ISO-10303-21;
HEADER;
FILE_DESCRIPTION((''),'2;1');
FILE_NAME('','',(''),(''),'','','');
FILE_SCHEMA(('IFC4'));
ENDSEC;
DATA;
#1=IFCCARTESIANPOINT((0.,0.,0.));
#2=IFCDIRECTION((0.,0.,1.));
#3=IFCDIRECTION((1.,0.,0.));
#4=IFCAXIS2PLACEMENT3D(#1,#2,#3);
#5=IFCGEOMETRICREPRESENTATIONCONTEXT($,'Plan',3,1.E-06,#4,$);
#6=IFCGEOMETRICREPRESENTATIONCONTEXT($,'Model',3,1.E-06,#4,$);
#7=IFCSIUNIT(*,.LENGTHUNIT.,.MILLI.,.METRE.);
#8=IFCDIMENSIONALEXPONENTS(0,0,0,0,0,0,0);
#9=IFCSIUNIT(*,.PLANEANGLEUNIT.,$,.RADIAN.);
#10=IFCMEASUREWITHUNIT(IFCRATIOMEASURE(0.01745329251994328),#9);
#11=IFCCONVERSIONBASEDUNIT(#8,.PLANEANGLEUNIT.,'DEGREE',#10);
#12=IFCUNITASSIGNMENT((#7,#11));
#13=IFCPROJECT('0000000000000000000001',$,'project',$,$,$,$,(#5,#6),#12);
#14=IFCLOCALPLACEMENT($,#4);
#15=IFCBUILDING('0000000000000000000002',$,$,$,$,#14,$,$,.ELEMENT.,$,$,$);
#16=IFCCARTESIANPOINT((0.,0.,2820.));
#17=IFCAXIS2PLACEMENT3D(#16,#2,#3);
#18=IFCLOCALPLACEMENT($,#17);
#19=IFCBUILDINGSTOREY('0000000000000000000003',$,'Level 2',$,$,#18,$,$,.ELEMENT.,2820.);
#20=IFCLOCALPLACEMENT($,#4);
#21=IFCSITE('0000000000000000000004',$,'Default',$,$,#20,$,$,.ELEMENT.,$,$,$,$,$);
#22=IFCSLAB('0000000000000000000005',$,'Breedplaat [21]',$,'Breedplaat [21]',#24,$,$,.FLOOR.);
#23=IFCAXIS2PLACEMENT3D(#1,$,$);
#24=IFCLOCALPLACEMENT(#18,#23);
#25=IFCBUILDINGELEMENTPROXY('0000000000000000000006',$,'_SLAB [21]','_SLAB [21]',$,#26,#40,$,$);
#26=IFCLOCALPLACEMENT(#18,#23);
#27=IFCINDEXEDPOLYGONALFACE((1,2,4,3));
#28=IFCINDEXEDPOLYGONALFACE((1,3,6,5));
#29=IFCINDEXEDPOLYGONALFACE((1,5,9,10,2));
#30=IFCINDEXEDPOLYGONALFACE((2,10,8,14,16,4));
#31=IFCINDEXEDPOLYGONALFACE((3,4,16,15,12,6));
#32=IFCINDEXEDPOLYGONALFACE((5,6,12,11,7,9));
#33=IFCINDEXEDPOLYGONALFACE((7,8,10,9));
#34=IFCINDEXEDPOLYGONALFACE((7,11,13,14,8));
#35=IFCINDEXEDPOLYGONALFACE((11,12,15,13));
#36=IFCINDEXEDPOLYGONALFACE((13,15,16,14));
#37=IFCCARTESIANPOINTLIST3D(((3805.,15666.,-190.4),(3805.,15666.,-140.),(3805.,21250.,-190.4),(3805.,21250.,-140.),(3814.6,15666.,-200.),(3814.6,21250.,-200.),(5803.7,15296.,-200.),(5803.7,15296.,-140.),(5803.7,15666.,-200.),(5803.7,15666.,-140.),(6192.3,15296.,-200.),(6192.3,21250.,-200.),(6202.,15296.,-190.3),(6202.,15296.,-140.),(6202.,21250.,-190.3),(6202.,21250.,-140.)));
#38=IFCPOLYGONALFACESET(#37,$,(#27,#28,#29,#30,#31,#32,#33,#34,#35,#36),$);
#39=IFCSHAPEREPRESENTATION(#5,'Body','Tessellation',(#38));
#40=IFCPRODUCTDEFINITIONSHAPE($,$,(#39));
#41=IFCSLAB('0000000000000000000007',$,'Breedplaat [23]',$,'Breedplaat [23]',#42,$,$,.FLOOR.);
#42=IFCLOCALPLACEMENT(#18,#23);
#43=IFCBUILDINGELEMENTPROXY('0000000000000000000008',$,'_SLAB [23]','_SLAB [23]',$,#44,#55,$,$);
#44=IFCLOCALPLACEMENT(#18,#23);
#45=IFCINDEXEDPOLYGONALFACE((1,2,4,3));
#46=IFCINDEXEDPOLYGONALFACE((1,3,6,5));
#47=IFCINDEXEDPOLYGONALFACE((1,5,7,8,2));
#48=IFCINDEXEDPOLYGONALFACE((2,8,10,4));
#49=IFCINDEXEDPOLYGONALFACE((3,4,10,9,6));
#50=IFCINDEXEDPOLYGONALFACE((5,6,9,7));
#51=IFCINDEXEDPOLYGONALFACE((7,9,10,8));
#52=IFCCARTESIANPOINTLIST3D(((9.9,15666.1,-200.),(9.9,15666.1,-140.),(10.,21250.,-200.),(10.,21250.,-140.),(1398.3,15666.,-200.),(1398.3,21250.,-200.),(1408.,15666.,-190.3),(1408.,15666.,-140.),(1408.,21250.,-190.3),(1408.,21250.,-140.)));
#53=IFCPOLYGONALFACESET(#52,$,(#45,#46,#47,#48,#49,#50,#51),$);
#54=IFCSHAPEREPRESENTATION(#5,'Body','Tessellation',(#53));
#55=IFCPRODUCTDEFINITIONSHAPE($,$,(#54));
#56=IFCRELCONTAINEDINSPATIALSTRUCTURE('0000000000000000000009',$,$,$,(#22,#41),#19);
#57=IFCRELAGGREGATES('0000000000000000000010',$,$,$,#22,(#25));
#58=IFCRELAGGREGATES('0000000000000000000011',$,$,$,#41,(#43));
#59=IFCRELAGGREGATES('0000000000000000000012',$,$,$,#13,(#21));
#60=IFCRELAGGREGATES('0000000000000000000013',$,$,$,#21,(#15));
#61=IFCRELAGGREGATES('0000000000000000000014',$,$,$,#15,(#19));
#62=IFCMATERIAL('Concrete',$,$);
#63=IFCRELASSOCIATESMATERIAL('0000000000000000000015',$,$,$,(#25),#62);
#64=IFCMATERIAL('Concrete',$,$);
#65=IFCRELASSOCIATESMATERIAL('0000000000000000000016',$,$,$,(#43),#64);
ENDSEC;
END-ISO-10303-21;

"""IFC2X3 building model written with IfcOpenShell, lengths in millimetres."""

from ifc_helpers import new_model, entity, si_unit, converted_unit, frame, origin_with_axes, place, context, project, spatial, polyline, outline, extrude, material, element, aggregate, save


model = new_model("IFC2X3")

# Units and contexts
plan_context = context("Plan", 3, precision=1e-06, world=origin_with_axes())
model_context = context("Model", 3, precision=1e-06, world=origin_with_axes())
ifc_project = project(units=[si_unit("LENGTHUNIT", "METRE", prefix="MILLI"), converted_unit("PLANEANGLEUNIT", "DEGREE", entity("IfcRatioMeasure", 0.01745329251994328), si_unit("PLANEANGLEUNIT", "RADIAN"), dimensions=[0, 0, 0, 0, 0, 0, 0])], contexts=[plan_context, model_context])

# Site, building, storey
site_placement = place(None, origin_with_axes())
site = spatial("IfcSite", under=ifc_project, at=site_placement, Name="Default", CompositionType="ELEMENT")
building_placement = place(None, origin_with_axes())
building = spatial("IfcBuilding", under=site, at=building_placement, CompositionType="ELEMENT")
storey_placement = place(None, frame((0.0, 0.0, 2820.0), z_axis=(0.0, 0.0, 1.0), x_axis=(1.0, 0.0, 0.0)))
storey = spatial("IfcBuildingStorey", under=building, at=storey_placement, Name="Level 2", CompositionType="ELEMENT", Elevation=2820.0)

# Slab, building element proxy, openings
slab_1_placement = place(None, frame((6202.0, 15296.0, 2620.0), z_axis=(0.0, 0.0, 1.0), x_axis=(0.0, 1.0, 0.0)))
slab_1 = element("IfcSlab", 1, at=slab_1_placement, inside=storey, Name="Breedplaat [21]", ObjectType="Breedplaat [21]", PredefinedType="FLOOR")
ifc_material_1 = material(Name="Concrete")
proxy_1_placement = place(slab_1_placement, origin_with_axes())
proxy_1 = element("IfcBuildingElementProxy", 2, at=proxy_1_placement, material=ifc_material_1, Name="_SLAB [21]", Description="_SLAB [21]", context=plan_context, shape_type="SweptSolid", body=[
    extrude(outline(polyline([(370.0, 2397.0), (370.0, 398.3), (0.0, 398.3), (0.0, 0.0), (5954.0, 0.0), (5954.0, 2397.0), (370.0, 2397.0)])), origin_with_axes(), (0.0, 0.0, 1.0), 60.0),
])
opening_1_placement = place(None, frame((6202.0, 15296.0, 2620.0), z_axis=(0.0, 0.0, 1.0), x_axis=(0.0, 1.0, 0.0)))
element("IfcOpeningElement", 3, at=opening_1_placement, cuts=proxy_1, ObjectType="Opening", context=plan_context, shape_type="SweptSolid", body=[
    extrude(outline(polyline([(-0.1, -0.1), (-0.1, 10.0), (10.0, -0.1), (-0.1, -0.1)])), frame((-1.2, -0.1, -0.1), z_axis=(1.0, 0.0, 0.0), x_axis=(0.0, 1.0, 0.0)), (0.0, 0.0, 1.0), 5956.2),
])
opening_2_placement = place(None, frame((6202.0, 15296.0, 2620.0), z_axis=(0.0, 0.0, 1.0), x_axis=(0.0, 1.0, 0.0)))
element("IfcOpeningElement", 4, at=opening_2_placement, cuts=proxy_1, ObjectType="Opening", context=plan_context, shape_type="SweptSolid", body=[
    extrude(outline(polyline([(-0.1, -0.1), (-0.1, 10.0), (10.0, -0.1), (-0.1, -0.1)])), frame((5955.2, 2397.2, -0.1), z_axis=(-1.0, 0.0, 0.0), x_axis=(0.0, -1.0, 0.0)), (0.0, 0.0, 1.0), 5586.2),
])
aggregate(slab_1, [proxy_1])

# Slab, building element proxy, opening
slab_2_placement = place(None, frame((1408.0, 15666.0, 2620.0), z_axis=(0.0, 0.0, 1.0), x_axis=(0.0, 1.0, 0.0)))
slab_2 = element("IfcSlab", 5, at=slab_2_placement, inside=storey, Name="Breedplaat [23]", ObjectType="Breedplaat [23]", PredefinedType="FLOOR")
ifc_material_2 = material(Name="Concrete")
proxy_2_placement = place(slab_2_placement, origin_with_axes())
proxy_2 = element("IfcBuildingElementProxy", 6, at=proxy_2_placement, material=ifc_material_2, Name="_SLAB [23]", Description="_SLAB [23]", context=plan_context, shape_type="SweptSolid", body=[
    extrude(outline(polyline([(0.0, 0.0), (5584.0, 0.0), (5584.0, 1398.0), (0.0, 1398.0), (0.0, 0.0)])), origin_with_axes(), (0.0, 0.0, 1.0), 60.0),
])
opening_3_placement = place(None, frame((1408.0, 15666.0, 2620.0), z_axis=(0.0, 0.0, 1.0), x_axis=(0.0, 1.0, 0.0)))
element("IfcOpeningElement", 7, at=opening_3_placement, cuts=proxy_2, ObjectType="Opening", context=plan_context, shape_type="SweptSolid", body=[
    extrude(outline(polyline([(-0.1, -0.1), (-0.1, 10.0), (10.0, -0.1), (-0.1, -0.1)])), frame((-1.2, -0.1, -0.1), z_axis=(1.0, 0.0, 0.0), x_axis=(0.0, 1.0, 0.0)), (0.0, 0.0, 1.0), 5586.2),
])
aggregate(slab_2, [proxy_2])

save(model, "model.ifc")
